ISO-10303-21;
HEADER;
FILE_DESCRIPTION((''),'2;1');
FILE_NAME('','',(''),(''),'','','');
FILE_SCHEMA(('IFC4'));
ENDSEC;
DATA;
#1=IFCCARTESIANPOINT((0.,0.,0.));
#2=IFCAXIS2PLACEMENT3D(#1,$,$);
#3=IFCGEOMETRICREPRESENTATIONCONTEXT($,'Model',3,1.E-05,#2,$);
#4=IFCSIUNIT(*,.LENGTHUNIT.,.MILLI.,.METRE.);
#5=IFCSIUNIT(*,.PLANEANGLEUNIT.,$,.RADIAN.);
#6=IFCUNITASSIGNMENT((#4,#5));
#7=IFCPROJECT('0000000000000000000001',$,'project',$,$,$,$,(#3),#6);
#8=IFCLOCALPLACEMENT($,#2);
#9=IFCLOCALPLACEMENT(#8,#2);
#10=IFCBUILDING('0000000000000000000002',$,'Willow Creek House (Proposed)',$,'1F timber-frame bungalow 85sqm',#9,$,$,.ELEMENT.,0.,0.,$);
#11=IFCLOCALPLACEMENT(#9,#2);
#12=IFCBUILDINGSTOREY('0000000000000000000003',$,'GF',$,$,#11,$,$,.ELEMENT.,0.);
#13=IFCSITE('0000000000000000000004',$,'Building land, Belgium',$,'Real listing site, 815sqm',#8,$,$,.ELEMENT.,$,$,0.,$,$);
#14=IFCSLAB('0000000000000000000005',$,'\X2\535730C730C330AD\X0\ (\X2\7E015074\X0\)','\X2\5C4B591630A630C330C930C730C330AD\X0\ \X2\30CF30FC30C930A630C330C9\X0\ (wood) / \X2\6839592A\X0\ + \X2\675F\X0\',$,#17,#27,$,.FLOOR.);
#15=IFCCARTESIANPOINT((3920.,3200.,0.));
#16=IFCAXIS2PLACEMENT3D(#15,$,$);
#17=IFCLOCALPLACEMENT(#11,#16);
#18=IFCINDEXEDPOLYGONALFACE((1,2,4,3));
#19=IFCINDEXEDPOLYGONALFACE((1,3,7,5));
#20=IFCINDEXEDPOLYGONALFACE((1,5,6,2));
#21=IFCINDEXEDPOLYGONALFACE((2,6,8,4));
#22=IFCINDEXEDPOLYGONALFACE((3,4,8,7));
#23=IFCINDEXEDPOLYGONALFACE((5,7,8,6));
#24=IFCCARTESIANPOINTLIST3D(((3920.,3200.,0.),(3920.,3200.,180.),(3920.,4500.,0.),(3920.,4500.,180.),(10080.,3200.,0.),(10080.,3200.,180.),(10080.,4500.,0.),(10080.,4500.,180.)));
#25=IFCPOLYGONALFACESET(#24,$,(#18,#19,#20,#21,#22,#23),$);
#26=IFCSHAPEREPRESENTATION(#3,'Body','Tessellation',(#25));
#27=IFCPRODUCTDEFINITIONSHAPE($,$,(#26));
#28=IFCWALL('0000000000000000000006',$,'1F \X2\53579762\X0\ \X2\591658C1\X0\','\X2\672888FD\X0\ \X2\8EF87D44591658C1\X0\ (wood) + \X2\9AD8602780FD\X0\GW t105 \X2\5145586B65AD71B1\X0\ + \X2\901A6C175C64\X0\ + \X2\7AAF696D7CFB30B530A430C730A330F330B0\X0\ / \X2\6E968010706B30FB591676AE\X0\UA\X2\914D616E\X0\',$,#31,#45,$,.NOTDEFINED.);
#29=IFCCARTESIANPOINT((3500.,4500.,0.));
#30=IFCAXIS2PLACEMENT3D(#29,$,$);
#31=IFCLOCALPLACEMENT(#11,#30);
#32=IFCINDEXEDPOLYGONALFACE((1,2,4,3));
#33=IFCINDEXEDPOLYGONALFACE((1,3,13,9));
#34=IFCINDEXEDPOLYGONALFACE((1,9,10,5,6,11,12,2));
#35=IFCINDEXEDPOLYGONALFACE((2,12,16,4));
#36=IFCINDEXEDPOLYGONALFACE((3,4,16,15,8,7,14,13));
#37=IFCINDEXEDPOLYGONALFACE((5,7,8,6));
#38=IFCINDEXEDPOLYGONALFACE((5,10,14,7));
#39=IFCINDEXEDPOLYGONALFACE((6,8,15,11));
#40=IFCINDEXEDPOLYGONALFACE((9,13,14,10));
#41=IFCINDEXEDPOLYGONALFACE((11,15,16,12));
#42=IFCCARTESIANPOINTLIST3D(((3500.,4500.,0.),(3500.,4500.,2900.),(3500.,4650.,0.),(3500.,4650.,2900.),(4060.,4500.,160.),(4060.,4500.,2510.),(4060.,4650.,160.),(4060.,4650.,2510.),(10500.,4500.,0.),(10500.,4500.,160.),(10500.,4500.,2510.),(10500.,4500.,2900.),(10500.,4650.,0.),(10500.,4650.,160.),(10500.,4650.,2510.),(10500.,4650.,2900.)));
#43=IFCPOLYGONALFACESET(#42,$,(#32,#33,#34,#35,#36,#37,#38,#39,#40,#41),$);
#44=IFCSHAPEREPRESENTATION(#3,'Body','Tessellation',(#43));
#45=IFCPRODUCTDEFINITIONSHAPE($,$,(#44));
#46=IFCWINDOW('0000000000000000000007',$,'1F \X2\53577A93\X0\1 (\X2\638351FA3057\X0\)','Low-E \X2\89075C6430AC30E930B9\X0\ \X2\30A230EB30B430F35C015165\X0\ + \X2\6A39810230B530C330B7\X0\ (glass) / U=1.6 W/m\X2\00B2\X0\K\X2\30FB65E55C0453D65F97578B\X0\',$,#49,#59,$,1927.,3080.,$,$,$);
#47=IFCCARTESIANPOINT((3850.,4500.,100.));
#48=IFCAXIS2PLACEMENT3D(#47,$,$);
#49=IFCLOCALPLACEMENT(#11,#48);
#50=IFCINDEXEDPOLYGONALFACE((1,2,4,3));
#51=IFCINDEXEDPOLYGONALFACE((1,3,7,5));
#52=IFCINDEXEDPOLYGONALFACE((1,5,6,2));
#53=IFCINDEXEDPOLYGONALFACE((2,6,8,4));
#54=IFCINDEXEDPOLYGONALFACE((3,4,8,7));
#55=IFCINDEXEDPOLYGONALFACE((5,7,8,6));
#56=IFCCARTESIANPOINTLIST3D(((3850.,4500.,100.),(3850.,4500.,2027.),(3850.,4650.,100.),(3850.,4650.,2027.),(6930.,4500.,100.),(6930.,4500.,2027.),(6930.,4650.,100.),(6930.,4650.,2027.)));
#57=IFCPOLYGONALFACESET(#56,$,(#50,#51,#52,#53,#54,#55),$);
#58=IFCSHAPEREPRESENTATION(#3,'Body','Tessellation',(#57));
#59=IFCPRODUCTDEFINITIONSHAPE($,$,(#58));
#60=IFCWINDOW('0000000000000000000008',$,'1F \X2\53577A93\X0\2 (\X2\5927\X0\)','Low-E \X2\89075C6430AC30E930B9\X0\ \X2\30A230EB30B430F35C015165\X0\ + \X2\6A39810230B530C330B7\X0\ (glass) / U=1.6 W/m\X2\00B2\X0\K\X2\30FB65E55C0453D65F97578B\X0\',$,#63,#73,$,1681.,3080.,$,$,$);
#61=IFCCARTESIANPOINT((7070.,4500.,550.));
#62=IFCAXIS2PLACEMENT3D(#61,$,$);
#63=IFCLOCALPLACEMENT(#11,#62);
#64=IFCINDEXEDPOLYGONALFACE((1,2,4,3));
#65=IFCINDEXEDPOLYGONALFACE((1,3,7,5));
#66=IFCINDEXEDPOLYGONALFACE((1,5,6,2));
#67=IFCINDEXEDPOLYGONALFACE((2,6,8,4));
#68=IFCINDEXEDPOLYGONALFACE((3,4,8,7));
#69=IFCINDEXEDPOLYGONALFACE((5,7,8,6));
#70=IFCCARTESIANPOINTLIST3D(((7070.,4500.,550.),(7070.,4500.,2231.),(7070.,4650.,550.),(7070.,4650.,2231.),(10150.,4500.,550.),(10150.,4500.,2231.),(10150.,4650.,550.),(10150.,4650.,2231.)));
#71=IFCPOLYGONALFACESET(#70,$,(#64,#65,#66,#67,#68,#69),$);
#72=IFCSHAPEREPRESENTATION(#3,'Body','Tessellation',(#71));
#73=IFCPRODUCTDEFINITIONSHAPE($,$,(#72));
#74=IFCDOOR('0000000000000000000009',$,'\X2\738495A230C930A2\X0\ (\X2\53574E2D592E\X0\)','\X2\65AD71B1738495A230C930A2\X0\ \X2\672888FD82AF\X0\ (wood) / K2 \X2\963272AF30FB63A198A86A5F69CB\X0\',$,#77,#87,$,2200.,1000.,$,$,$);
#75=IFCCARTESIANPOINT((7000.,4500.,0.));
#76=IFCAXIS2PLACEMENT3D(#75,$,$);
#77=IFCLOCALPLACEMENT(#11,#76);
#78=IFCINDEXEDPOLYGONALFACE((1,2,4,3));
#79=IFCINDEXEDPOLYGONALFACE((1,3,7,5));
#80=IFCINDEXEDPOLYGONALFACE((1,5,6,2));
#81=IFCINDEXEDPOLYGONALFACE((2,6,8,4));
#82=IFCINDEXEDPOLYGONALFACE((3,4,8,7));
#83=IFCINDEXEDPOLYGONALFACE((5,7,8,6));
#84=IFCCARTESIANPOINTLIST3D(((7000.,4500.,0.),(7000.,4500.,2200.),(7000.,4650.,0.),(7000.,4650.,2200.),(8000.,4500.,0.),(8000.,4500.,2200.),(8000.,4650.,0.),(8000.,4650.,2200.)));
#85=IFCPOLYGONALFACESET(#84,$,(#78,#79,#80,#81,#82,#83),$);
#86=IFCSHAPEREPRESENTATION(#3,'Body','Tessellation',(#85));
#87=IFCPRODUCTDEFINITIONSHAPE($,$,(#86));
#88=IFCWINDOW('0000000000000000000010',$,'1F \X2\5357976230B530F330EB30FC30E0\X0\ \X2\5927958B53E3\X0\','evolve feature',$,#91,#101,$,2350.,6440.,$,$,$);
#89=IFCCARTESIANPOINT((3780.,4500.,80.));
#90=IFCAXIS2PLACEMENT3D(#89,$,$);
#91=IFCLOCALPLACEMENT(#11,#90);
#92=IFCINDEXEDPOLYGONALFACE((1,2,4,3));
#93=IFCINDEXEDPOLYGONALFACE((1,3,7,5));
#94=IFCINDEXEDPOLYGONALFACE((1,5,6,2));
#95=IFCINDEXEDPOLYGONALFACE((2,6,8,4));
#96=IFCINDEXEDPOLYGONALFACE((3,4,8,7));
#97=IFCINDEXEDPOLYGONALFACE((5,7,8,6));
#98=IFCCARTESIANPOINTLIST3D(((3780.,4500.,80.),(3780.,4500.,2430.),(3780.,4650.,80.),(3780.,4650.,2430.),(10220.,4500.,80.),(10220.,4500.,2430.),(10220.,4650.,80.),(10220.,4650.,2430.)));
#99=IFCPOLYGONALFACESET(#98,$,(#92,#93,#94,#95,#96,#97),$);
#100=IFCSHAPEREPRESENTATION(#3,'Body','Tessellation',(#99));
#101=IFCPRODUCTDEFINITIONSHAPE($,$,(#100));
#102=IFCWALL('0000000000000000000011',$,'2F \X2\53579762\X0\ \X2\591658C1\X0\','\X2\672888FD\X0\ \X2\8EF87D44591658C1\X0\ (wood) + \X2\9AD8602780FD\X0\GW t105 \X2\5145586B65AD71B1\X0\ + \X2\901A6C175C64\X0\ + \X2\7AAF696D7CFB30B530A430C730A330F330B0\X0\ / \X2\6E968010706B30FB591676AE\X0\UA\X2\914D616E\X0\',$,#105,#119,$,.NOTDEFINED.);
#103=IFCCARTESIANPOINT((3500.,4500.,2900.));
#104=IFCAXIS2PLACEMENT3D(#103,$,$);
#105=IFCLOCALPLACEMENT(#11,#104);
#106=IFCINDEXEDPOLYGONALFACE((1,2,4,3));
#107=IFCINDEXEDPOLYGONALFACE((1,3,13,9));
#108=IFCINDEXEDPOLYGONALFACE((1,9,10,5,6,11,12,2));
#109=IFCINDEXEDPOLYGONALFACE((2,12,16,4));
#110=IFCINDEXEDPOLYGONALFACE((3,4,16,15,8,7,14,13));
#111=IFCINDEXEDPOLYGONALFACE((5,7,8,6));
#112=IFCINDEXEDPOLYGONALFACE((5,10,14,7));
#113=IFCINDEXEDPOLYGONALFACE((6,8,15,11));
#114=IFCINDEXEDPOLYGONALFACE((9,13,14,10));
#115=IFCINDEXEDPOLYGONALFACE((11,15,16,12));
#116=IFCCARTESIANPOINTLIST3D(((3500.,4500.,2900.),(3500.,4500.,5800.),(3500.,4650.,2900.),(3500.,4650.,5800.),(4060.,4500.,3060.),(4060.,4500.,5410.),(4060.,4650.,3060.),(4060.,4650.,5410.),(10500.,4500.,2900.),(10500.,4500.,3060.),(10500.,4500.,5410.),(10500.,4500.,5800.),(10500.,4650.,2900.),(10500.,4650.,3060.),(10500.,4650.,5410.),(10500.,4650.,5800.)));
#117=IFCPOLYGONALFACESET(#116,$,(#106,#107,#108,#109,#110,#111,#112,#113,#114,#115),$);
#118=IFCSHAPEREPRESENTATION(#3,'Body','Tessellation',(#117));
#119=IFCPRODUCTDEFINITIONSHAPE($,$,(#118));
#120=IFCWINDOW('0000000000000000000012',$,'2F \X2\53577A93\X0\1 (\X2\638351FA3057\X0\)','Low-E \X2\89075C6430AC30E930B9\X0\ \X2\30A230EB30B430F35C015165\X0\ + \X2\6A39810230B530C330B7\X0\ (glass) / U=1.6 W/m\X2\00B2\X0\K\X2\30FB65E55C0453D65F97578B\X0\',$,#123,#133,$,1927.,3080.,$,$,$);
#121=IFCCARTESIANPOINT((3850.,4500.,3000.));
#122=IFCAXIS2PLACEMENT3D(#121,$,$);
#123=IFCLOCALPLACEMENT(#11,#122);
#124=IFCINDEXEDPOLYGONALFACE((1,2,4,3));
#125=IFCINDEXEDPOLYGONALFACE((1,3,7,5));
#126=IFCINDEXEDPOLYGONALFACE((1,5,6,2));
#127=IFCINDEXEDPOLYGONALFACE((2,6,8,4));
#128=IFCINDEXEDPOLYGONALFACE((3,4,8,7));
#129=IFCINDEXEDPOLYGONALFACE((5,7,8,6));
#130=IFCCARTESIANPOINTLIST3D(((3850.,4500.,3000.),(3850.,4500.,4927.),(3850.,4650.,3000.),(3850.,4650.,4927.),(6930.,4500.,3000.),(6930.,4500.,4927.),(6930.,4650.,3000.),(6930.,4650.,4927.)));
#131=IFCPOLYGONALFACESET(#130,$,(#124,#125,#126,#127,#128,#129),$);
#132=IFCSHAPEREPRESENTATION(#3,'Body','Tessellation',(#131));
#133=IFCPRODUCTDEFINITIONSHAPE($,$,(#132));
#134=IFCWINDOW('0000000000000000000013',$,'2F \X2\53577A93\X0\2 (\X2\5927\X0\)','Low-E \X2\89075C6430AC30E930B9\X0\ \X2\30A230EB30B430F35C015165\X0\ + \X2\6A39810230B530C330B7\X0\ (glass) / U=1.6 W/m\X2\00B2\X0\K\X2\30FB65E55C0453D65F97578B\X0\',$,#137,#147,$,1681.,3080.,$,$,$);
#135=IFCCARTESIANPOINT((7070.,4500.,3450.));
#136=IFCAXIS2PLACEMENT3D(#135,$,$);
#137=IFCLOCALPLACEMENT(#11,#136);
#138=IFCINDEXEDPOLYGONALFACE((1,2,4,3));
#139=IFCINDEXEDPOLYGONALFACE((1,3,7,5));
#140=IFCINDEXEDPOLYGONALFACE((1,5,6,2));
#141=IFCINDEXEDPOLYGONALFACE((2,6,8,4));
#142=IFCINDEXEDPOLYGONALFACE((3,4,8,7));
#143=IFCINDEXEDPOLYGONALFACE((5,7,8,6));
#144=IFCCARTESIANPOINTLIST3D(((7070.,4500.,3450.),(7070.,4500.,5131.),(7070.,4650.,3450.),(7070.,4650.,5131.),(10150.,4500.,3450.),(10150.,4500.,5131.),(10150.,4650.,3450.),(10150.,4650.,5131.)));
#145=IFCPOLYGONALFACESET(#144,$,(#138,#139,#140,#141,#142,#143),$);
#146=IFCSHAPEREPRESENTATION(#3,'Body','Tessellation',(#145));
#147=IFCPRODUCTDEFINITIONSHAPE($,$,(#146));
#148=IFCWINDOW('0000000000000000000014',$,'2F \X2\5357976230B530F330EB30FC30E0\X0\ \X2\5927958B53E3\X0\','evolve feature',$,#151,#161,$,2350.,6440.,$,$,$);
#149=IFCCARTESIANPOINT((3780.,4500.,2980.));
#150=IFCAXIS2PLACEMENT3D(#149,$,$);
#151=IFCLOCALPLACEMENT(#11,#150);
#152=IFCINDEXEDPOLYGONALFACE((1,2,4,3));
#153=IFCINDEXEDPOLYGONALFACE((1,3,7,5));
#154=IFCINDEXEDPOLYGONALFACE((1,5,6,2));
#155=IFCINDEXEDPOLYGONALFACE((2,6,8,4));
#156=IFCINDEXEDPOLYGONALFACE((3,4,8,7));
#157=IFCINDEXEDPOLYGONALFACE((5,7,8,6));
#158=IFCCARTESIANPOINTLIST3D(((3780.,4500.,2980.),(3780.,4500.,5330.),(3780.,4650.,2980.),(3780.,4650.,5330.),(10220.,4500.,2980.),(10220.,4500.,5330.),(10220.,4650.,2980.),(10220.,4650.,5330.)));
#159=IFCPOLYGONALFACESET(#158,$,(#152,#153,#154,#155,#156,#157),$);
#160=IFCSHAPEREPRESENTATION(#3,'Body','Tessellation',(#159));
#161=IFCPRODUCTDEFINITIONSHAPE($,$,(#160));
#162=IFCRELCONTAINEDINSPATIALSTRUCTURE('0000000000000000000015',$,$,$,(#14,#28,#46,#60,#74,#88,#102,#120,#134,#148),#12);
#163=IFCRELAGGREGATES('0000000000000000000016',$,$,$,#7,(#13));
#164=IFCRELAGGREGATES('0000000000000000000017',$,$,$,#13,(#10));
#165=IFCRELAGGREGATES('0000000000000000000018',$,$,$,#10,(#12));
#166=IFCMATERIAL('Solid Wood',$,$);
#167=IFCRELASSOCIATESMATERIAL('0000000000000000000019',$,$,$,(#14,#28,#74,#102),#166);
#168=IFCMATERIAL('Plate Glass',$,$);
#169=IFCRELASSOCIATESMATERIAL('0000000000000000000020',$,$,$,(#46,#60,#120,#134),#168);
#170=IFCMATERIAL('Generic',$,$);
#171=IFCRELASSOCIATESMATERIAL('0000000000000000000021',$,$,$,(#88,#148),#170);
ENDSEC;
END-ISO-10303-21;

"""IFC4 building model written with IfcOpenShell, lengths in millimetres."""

from ifc_helpers import new_model, si_unit, frame, frame_2d, origin, place, context, project, spatial, rectangle, extrude, material, element, fill, save


model = new_model("IFC4")

# Units and contexts
model_context = context("Model", 3, precision=1e-05, world=origin())
ifc_project = project(units=[si_unit("LENGTHUNIT", "METRE", prefix="MILLI"), si_unit("PLANEANGLEUNIT", "RADIAN")], contexts=[model_context])

# Site, building, storey
site_placement = place(None, origin())
site = spatial("IfcSite", under=ifc_project, at=site_placement, Name="Building land, Belgium", ObjectType="Real listing site, 815sqm", CompositionType="ELEMENT", RefElevation=0.0)
building_placement = place(site_placement, origin())
building = spatial("IfcBuilding", under=site, at=building_placement, Name="Willow Creek House (Proposed)", ObjectType="1F timber-frame bungalow 85sqm", CompositionType="ELEMENT", ElevationOfRefHeight=0.0, ElevationOfTerrain=0.0)
storey_placement = place(building_placement, origin())
storey = spatial("IfcBuildingStorey", under=building, at=storey_placement, Name="GF", CompositionType="ELEMENT", Elevation=0.0)

# Slab
ifc_material_1 = material(Name="Solid Wood")
slab_1_placement = place(storey_placement, frame((3920.0, 3200.0, 0.0)))
element("IfcSlab", 1, at=slab_1_placement, inside=storey, material=ifc_material_1, Name="南デッキ (縁側)", Description="屋外ウッドデッキ ハードウッド (wood) / 根太 + 束", PredefinedType="FLOOR", context=model_context, shape_type="SweptSolid", body=[
    extrude(rectangle(XDim=6160.0, YDim=1300.0, at=frame_2d((3080.0, 650.0))), frame((3920.0, 3200.0, 0.0)), (0.0, 0.0, 1.0), 180.0),
])
ifc_material_2 = material(Name="Generic")

# Wall, openings, windows, door
wall_1_placement = place(storey_placement, frame((3500.0, 4500.0, 0.0)))
wall_1 = element("IfcWall", 2, at=wall_1_placement, inside=storey, material=ifc_material_1, Name="1F 南面 外壁", Description="木製 軸組外壁 (wood) + 高性能GW t105 充填断熱 + 通気層 + 窯業系サイディング / 準耐火・外皮UA配慮", PredefinedType="NOTDEFINED", context=model_context, shape_type="SweptSolid", body=[
    extrude(rectangle(XDim=7000.0, YDim=150.0, at=frame_2d((3500.0, 75.0))), frame((3500.0, 4500.0, 0.0)), (0.0, 0.0, 1.0), 2900.0),
])
opening_1_placement = place(storey_placement, frame((3850.0, 4500.0, 100.0)))
opening_1 = element("IfcOpeningElement", 3, at=opening_1_placement, cuts=wall_1, PredefinedType="NOTDEFINED", context=model_context, shape_type="SweptSolid", body=[
    extrude(rectangle(XDim=3080.0, YDim=150.0, at=frame_2d((1540.0, 75.0))), frame((3850.0, 4500.0, 100.0)), (0.0, 0.0, 1.0), 1927.0),
])
opening_2_placement = place(storey_placement, frame((7070.0, 4500.0, 550.0)))
opening_2 = element("IfcOpeningElement", 4, at=opening_2_placement, cuts=wall_1, PredefinedType="NOTDEFINED", context=model_context, shape_type="SweptSolid", body=[
    extrude(rectangle(XDim=3080.0, YDim=150.0, at=frame_2d((1540.0, 75.0))), frame((7070.0, 4500.0, 550.0)), (0.0, 0.0, 1.0), 1681.0),
])
opening_3_placement = place(storey_placement, frame((7000.0, 4500.0, 0.0)))
opening_3 = element("IfcOpeningElement", 5, at=opening_3_placement, cuts=wall_1, PredefinedType="NOTDEFINED", context=model_context, shape_type="SweptSolid", body=[
    extrude(rectangle(XDim=1000.0, YDim=150.0, at=frame_2d((500.0, 75.0))), frame((7000.0, 4500.0, 0.0)), (0.0, 0.0, 1.0), 2200.0),
])
opening_4_placement = place(storey_placement, frame((3780.0, 4500.0, 80.0)))
opening_4 = element("IfcOpeningElement", 6, at=opening_4_placement, cuts=wall_1, PredefinedType="NOTDEFINED", context=model_context, shape_type="SweptSolid", body=[
    extrude(rectangle(XDim=6440.0, YDim=150.0, at=frame_2d((3220.0, 75.0))), frame((3780.0, 4500.0, 80.0)), (0.0, 0.0, 1.0), 2350.0),
])
ifc_material_3 = material(Name="Plate Glass")
window_1_placement = place(storey_placement, frame((3850.0, 4500.0, 100.0)))
window_1 = element("IfcWindow", 7, at=window_1_placement, inside=storey, material=ifc_material_3, Name="1F 南窓1 (掃出し)", Description="Low-E 複層ガラス アルゴン封入 + 樹脂サッシ (glass) / U=1.6 W/m²K・日射取得型", OverallHeight=1927.0, OverallWidth=3080.0, context=model_context, shape_type="SweptSolid", body=[
    extrude(rectangle(XDim=3080.0, YDim=150.0, at=frame_2d((1540.0, 75.0))), frame((3850.0, 4500.0, 100.0)), (0.0, 0.0, 1.0), 1927.0),
])
fill(opening_1, window_1)
window_2_placement = place(storey_placement, frame((7070.0, 4500.0, 550.0)))
window_2 = element("IfcWindow", 8, at=window_2_placement, inside=storey, material=ifc_material_3, Name="1F 南窓2 (大)", Description="Low-E 複層ガラス アルゴン封入 + 樹脂サッシ (glass) / U=1.6 W/m²K・日射取得型", OverallHeight=1681.0, OverallWidth=3080.0, context=model_context, shape_type="SweptSolid", body=[
    extrude(rectangle(XDim=3080.0, YDim=150.0, at=frame_2d((1540.0, 75.0))), frame((7070.0, 4500.0, 550.0)), (0.0, 0.0, 1.0), 1681.0),
])
fill(opening_2, window_2)
door_placement = place(storey_placement, frame((7000.0, 4500.0, 0.0)))
door = element("IfcDoor", 9, at=door_placement, inside=storey, material=ifc_material_1, Name="玄関ドア (南中央)", Description="断熱玄関ドア 木製芯 (wood) / K2 防犯・採風機構", OverallHeight=2200.0, OverallWidth=1000.0, context=model_context, shape_type="SweptSolid", body=[
    extrude(rectangle(XDim=1000.0, YDim=150.0, at=frame_2d((500.0, 75.0))), frame((7000.0, 4500.0, 0.0)), (0.0, 0.0, 1.0), 2200.0),
])
fill(opening_3, door)
window_3_placement = place(storey_placement, frame((3780.0, 4500.0, 80.0)))
window_3 = element("IfcWindow", 10, at=window_3_placement, inside=storey, material=ifc_material_2, Name="1F 南面サンルーム 大開口", Description="evolve feature", OverallHeight=2350.0, OverallWidth=6440.0, context=model_context, shape_type="SweptSolid", body=[
    extrude(rectangle(XDim=6440.0, YDim=150.0, at=frame_2d((3220.0, 75.0))), frame((3780.0, 4500.0, 80.0)), (0.0, 0.0, 1.0), 2350.0),
])
fill(opening_4, window_3)

# Wall, openings, windows
wall_2_placement = place(storey_placement, frame((3500.0, 4500.0, 2900.0)))
wall_2 = element("IfcWall", 11, at=wall_2_placement, inside=storey, material=ifc_material_1, Name="2F 南面 外壁", Description="木製 軸組外壁 (wood) + 高性能GW t105 充填断熱 + 通気層 + 窯業系サイディング / 準耐火・外皮UA配慮", PredefinedType="NOTDEFINED", context=model_context, shape_type="SweptSolid", body=[
    extrude(rectangle(XDim=7000.0, YDim=150.0, at=frame_2d((3500.0, 75.0))), frame((3500.0, 4500.0, 2900.0)), (0.0, 0.0, 1.0), 2900.0),
])
opening_5_placement = place(storey_placement, frame((3850.0, 4500.0, 3000.0)))
opening_5 = element("IfcOpeningElement", 12, at=opening_5_placement, cuts=wall_2, PredefinedType="NOTDEFINED", context=model_context, shape_type="SweptSolid", body=[
    extrude(rectangle(XDim=3080.0, YDim=150.0, at=frame_2d((1540.0, 75.0))), frame((3850.0, 4500.0, 3000.0)), (0.0, 0.0, 1.0), 1927.0),
])
opening_6_placement = place(storey_placement, frame((7070.0, 4500.0, 3450.0)))
opening_6 = element("IfcOpeningElement", 13, at=opening_6_placement, cuts=wall_2, PredefinedType="NOTDEFINED", context=model_context, shape_type="SweptSolid", body=[
    extrude(rectangle(XDim=3080.0, YDim=150.0, at=frame_2d((1540.0, 75.0))), frame((7070.0, 4500.0, 3450.0)), (0.0, 0.0, 1.0), 1681.0),
])
opening_7_placement = place(storey_placement, frame((3780.0, 4500.0, 2980.0)))
opening_7 = element("IfcOpeningElement", 14, at=opening_7_placement, cuts=wall_2, PredefinedType="NOTDEFINED", context=model_context, shape_type="SweptSolid", body=[
    extrude(rectangle(XDim=6440.0, YDim=150.0, at=frame_2d((3220.0, 75.0))), frame((3780.0, 4500.0, 2980.0)), (0.0, 0.0, 1.0), 2350.0),
])
window_4_placement = place(storey_placement, frame((3850.0, 4500.0, 3000.0)))
window_4 = element("IfcWindow", 15, at=window_4_placement, inside=storey, material=ifc_material_3, Name="2F 南窓1 (掃出し)", Description="Low-E 複層ガラス アルゴン封入 + 樹脂サッシ (glass) / U=1.6 W/m²K・日射取得型", OverallHeight=1927.0, OverallWidth=3080.0, context=model_context, shape_type="SweptSolid", body=[
    extrude(rectangle(XDim=3080.0, YDim=150.0, at=frame_2d((1540.0, 75.0))), frame((3850.0, 4500.0, 3000.0)), (0.0, 0.0, 1.0), 1927.0),
])
fill(opening_5, window_4)
window_5_placement = place(storey_placement, frame((7070.0, 4500.0, 3450.0)))
window_5 = element("IfcWindow", 16, at=window_5_placement, inside=storey, material=ifc_material_3, Name="2F 南窓2 (大)", Description="Low-E 複層ガラス アルゴン封入 + 樹脂サッシ (glass) / U=1.6 W/m²K・日射取得型", OverallHeight=1681.0, OverallWidth=3080.0, context=model_context, shape_type="SweptSolid", body=[
    extrude(rectangle(XDim=3080.0, YDim=150.0, at=frame_2d((1540.0, 75.0))), frame((7070.0, 4500.0, 3450.0)), (0.0, 0.0, 1.0), 1681.0),
])
fill(opening_6, window_5)
window_6_placement = place(storey_placement, frame((3780.0, 4500.0, 2980.0)))
window_6 = element("IfcWindow", 17, at=window_6_placement, inside=storey, material=ifc_material_2, Name="2F 南面サンルーム 大開口", Description="evolve feature", OverallHeight=2350.0, OverallWidth=6440.0, context=model_context, shape_type="SweptSolid", body=[
    extrude(rectangle(XDim=6440.0, YDim=150.0, at=frame_2d((3220.0, 75.0))), frame((3780.0, 4500.0, 2980.0)), (0.0, 0.0, 1.0), 2350.0),
])
fill(opening_7, window_6)

save(model, "model.ifc")
